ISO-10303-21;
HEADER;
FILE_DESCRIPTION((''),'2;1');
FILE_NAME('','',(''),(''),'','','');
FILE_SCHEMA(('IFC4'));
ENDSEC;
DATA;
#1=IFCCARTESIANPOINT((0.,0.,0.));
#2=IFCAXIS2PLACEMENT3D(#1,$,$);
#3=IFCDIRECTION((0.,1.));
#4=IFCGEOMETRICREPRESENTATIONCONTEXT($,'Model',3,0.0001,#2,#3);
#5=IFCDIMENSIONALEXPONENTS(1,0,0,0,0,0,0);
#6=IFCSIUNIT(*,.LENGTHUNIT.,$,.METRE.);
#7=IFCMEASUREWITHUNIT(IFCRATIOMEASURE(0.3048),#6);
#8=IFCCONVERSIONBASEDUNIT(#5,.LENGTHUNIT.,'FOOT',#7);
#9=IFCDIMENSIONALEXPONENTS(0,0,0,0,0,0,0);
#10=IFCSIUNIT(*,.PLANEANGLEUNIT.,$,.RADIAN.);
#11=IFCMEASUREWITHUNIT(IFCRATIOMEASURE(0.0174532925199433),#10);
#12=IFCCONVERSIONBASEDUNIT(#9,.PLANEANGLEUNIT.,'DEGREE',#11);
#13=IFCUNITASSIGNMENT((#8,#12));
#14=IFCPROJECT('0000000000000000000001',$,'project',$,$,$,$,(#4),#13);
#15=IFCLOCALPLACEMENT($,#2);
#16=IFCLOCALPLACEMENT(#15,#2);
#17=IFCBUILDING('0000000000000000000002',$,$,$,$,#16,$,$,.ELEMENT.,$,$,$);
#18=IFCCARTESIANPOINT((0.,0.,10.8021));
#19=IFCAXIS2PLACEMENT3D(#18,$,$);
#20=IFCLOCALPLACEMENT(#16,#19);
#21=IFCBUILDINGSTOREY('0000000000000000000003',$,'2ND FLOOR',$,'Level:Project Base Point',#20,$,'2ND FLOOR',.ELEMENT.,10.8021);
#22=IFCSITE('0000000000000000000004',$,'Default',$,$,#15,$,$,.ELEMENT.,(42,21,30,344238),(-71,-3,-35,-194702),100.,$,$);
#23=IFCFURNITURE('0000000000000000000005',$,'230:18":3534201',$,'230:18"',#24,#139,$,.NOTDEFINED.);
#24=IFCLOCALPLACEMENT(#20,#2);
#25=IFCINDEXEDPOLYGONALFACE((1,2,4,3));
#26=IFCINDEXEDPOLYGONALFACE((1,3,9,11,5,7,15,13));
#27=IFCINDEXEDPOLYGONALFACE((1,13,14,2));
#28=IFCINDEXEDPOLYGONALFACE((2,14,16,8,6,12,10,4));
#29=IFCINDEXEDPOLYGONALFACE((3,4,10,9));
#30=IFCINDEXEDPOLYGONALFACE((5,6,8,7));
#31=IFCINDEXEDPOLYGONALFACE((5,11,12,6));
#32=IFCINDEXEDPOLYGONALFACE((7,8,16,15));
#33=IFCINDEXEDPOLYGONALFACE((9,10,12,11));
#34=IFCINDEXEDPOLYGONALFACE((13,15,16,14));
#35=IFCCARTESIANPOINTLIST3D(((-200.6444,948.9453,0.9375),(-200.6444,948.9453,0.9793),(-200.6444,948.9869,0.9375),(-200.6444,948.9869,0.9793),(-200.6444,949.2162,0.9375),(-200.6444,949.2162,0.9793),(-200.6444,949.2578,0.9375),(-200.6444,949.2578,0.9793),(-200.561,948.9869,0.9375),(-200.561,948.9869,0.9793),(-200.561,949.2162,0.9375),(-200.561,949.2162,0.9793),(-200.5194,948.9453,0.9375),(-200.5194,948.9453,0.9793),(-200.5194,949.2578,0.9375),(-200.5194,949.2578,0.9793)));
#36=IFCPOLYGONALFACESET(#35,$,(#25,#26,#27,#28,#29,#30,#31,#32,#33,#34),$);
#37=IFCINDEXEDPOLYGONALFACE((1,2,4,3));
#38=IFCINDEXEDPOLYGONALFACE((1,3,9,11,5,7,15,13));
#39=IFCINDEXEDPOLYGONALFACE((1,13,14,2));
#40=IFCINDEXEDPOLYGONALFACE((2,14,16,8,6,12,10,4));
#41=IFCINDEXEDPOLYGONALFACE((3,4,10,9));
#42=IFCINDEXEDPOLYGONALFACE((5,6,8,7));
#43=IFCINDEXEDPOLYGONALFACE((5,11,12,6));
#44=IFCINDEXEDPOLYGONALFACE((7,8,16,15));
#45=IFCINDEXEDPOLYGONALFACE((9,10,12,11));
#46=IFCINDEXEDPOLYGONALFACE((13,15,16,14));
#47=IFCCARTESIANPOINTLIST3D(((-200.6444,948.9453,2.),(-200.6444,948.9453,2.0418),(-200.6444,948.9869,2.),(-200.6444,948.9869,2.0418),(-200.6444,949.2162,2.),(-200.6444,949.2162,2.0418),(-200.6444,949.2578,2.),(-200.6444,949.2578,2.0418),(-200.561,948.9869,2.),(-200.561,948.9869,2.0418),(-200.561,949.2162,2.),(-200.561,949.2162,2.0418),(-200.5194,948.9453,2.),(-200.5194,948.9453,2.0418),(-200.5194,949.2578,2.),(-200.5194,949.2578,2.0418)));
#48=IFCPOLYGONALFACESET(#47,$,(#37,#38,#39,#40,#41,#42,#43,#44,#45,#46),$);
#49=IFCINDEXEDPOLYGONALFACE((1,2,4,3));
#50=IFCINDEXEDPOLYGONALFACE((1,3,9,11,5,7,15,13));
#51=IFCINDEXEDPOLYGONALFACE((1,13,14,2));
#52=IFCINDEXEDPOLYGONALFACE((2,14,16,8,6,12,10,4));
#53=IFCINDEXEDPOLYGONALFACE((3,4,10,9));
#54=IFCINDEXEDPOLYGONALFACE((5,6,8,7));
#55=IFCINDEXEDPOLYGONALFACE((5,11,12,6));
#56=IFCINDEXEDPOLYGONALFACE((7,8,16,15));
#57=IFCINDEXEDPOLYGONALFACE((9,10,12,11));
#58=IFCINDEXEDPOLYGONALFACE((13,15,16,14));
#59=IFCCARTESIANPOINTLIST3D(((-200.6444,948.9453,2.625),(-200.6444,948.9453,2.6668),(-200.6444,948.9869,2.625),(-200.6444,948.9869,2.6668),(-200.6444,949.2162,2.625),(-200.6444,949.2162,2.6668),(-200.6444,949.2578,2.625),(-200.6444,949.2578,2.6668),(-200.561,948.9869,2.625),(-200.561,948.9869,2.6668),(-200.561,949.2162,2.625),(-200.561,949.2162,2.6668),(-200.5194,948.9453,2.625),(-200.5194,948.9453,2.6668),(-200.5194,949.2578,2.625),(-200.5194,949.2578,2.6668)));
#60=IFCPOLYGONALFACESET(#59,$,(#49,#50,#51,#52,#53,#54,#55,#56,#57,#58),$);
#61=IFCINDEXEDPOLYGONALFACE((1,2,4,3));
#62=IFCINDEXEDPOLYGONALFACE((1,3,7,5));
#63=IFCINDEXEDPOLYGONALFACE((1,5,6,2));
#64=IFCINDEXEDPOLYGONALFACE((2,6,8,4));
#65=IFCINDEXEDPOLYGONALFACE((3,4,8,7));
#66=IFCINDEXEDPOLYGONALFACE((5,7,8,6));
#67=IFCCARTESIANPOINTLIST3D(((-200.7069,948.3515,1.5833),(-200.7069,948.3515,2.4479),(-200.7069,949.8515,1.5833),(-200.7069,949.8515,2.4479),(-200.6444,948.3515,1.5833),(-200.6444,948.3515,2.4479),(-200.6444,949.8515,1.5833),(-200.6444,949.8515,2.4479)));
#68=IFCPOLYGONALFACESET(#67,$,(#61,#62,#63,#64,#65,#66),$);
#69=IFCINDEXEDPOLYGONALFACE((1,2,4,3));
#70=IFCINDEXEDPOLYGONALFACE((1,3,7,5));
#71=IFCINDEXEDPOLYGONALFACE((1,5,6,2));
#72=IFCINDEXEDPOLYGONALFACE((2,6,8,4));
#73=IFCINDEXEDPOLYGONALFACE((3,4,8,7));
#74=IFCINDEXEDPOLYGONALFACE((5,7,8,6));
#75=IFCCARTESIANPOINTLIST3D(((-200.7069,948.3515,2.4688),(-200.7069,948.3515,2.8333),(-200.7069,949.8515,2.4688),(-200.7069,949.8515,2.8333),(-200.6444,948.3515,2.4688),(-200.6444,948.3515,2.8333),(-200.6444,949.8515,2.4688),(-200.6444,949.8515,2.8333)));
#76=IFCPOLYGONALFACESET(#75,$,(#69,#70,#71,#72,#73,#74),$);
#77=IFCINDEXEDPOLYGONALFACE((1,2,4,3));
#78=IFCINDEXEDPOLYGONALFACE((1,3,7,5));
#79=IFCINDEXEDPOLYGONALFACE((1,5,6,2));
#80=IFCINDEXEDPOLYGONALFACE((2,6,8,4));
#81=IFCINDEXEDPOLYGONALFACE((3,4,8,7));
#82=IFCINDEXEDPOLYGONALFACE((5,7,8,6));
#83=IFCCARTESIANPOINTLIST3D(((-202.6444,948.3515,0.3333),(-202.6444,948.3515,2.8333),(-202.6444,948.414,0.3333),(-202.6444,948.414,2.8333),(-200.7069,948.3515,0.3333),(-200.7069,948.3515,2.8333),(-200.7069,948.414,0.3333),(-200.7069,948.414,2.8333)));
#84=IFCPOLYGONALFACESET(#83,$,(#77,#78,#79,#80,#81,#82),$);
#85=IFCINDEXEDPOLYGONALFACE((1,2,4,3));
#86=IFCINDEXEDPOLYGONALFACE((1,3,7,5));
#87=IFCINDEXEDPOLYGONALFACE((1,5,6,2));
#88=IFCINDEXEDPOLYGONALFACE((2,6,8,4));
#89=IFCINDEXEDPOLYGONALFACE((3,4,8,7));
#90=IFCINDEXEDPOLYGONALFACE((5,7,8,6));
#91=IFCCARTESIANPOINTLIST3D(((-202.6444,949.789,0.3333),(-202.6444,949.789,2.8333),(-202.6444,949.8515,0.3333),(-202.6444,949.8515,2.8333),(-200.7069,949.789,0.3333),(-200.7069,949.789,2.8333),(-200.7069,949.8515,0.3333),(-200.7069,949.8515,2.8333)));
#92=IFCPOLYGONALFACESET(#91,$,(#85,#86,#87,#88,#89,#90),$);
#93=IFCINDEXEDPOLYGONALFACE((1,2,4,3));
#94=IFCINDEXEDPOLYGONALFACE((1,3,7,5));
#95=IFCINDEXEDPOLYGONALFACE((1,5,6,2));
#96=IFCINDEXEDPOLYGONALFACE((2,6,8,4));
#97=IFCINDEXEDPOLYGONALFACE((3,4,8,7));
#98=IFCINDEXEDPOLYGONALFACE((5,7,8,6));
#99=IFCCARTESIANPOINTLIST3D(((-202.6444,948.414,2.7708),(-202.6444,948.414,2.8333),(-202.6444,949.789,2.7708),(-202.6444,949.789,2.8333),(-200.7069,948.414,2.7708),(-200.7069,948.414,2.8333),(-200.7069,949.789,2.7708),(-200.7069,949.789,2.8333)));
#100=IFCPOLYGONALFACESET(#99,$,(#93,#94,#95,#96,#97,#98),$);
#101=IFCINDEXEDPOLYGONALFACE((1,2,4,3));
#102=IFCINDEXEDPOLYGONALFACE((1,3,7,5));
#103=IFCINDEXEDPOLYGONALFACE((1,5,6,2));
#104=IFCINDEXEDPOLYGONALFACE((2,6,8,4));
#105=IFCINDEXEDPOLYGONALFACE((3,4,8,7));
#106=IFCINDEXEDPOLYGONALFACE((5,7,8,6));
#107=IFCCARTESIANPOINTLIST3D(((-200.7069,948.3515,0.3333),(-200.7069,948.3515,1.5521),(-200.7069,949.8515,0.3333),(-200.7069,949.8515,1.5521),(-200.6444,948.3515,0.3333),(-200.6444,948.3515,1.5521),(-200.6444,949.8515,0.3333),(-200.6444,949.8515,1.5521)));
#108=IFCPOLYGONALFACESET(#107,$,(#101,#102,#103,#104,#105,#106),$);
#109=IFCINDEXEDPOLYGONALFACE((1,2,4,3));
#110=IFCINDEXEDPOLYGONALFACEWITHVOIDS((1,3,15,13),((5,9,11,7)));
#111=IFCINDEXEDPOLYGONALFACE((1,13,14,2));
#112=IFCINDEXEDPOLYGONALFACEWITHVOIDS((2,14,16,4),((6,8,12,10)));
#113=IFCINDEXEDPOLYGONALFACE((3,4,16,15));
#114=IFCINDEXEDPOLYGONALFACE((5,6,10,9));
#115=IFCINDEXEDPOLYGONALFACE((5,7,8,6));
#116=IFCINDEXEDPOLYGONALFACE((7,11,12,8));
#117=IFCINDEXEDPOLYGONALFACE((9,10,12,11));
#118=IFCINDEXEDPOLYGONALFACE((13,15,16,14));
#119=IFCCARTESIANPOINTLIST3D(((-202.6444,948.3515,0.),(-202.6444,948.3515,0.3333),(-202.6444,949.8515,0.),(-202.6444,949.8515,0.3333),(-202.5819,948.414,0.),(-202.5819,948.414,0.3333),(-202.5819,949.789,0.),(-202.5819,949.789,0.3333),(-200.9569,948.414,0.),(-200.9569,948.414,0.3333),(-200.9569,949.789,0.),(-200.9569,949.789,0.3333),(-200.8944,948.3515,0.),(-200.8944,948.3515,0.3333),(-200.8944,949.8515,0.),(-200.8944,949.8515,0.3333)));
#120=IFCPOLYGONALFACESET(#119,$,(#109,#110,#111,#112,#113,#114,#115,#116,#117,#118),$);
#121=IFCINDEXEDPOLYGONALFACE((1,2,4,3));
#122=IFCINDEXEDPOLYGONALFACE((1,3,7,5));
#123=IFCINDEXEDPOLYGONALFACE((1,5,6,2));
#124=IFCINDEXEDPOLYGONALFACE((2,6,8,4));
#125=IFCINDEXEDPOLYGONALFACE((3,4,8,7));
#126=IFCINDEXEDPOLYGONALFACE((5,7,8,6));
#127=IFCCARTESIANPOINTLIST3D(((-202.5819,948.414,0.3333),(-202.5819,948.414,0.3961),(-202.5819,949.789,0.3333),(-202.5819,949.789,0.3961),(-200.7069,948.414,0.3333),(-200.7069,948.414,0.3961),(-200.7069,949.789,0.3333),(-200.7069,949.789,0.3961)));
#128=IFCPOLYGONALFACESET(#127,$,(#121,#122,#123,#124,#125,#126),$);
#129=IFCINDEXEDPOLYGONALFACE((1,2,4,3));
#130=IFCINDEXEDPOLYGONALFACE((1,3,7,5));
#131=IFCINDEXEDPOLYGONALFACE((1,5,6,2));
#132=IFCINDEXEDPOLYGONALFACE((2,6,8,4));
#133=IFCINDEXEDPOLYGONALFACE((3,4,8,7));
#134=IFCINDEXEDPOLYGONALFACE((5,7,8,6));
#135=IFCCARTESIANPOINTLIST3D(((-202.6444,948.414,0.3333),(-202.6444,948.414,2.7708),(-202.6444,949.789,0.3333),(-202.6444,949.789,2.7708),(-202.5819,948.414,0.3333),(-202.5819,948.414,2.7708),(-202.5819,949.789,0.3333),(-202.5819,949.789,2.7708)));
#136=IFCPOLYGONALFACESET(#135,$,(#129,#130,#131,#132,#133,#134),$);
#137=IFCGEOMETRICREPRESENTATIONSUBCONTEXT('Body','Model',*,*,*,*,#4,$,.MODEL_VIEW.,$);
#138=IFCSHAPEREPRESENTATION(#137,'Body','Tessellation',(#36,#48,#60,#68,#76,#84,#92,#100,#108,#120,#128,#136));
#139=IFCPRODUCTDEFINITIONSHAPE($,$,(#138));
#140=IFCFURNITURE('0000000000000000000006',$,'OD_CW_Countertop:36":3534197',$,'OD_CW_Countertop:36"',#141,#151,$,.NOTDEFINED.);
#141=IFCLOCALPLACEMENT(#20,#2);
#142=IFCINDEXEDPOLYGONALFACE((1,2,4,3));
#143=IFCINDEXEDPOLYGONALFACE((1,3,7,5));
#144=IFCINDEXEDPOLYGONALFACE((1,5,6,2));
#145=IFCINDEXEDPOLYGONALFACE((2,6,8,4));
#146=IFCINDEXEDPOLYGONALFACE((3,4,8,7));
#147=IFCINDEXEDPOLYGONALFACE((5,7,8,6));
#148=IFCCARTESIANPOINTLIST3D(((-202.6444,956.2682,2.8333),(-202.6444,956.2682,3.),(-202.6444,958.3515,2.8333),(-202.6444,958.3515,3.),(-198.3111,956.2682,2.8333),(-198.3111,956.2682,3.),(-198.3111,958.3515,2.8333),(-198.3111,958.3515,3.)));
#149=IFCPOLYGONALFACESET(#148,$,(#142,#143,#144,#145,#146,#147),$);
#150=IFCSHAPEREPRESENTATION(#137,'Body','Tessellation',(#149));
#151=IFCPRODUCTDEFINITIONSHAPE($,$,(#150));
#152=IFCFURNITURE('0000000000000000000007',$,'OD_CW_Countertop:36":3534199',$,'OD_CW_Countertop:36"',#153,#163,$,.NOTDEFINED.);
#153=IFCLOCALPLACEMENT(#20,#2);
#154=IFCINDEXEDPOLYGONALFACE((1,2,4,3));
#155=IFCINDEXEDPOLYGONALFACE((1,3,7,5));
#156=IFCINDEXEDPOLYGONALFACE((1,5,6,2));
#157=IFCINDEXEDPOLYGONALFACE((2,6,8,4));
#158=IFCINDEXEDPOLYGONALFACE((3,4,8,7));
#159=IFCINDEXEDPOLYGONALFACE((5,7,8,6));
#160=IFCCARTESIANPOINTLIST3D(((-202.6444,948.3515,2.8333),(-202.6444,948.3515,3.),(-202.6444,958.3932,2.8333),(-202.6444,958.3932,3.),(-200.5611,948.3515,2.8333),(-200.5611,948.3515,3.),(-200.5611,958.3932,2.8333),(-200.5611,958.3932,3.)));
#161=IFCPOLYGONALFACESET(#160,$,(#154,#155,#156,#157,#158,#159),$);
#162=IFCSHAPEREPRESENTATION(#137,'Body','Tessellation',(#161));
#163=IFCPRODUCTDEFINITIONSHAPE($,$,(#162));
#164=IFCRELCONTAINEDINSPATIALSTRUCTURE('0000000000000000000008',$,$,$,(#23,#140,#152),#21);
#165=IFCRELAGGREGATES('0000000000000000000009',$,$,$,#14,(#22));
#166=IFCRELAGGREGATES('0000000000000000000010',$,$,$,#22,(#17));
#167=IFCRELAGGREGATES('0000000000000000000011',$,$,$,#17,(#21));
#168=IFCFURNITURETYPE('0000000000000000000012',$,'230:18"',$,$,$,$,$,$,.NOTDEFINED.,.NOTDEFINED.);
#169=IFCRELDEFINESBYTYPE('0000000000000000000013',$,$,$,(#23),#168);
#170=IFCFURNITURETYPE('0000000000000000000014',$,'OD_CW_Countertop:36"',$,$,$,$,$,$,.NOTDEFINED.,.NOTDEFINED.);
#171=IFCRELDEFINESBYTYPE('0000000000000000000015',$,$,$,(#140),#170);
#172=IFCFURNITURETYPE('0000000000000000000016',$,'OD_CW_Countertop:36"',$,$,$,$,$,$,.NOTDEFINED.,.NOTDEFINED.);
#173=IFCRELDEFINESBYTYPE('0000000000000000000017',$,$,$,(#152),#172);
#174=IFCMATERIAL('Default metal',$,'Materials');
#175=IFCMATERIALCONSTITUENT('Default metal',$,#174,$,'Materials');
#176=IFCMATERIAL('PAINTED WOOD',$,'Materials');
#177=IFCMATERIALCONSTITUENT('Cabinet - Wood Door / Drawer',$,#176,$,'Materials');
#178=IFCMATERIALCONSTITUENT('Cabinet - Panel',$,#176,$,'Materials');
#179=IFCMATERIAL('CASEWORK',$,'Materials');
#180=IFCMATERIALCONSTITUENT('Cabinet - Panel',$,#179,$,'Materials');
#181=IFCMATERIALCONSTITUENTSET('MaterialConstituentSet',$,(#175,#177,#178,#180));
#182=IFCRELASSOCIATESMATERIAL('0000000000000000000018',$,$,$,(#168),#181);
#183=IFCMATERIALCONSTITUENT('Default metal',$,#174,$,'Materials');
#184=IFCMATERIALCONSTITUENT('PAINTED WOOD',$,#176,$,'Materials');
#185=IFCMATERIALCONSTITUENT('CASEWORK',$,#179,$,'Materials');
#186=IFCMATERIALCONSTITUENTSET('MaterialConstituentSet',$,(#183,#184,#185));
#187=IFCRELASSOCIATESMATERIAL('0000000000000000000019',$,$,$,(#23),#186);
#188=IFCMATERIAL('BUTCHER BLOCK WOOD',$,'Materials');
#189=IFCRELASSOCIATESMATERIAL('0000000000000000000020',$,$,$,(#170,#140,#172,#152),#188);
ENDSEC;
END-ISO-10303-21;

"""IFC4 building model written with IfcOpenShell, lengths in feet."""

from ifc_helpers import new_model, entity, si_unit, converted_unit, direction, frame, frame_2d, origin, origin_2d_with_axis, place, context, subcontext, project, spatial, polyline, rectangle, outline, extrude, source, transform, mapped, material, constituent, constituent_set, type_object, type_shapes, element, save


model = new_model("IFC4")

# Units and contexts
model_context = context("Model", 3, precision=0.0001, world=origin(), true_north=direction((0.0, 1.0)))
body_context = subcontext(model_context, "Body", "Model", "MODEL_VIEW")
ifc_project = project(units=[converted_unit("LENGTHUNIT", "FOOT", entity("IfcRatioMeasure", 0.3048), si_unit("LENGTHUNIT", "METRE"), dimensions=[1, 0, 0, 0, 0, 0, 0]), converted_unit("PLANEANGLEUNIT", "DEGREE", entity("IfcRatioMeasure", 0.0174532925199433), si_unit("PLANEANGLEUNIT", "RADIAN"), dimensions=[0, 0, 0, 0, 0, 0, 0])], contexts=[model_context])

# Site, building, storey
site_placement = place(None, origin())
site = spatial("IfcSite", under=ifc_project, at=site_placement, Name="Default", CompositionType="ELEMENT", RefLatitude=(42, 21, 30, 344238), RefLongitude=(-71, -3, -35, -194702), RefElevation=100.0)
building_placement = place(site_placement, origin())
building = spatial("IfcBuilding", under=site, at=building_placement, CompositionType="ELEMENT")
storey_placement = place(building_placement, frame((0.0, 0.0, 10.8021)))
storey = spatial("IfcBuildingStorey", under=building, at=storey_placement, Name="2ND FLOOR", ObjectType="Level:Project Base Point", LongName="2ND FLOOR", CompositionType="ELEMENT", Elevation=10.8021)

# Furniture
ifc_material_1 = material(Name="CASEWORK", Category="Materials")
ifc_material_2 = material(Name="Default metal", Category="Materials")
ifc_material_3 = material(Name="PAINTED WOOD", Category="Materials")
ifc_constituent_1 = constituent(ifc_material_2, Name="Default metal", Category="Materials")
ifc_constituent_2 = constituent(ifc_material_3, Name="PAINTED WOOD", Category="Materials")
ifc_constituent_3 = constituent(ifc_material_1, Name="CASEWORK", Category="Materials")
ifc_constituent_set_1 = constituent_set(constituents=[ifc_constituent_1, ifc_constituent_2, ifc_constituent_3], Name="MaterialConstituentSet")
ifc_constituent_4 = constituent(ifc_material_2, Name="Default metal", Category="Materials")
ifc_constituent_5 = constituent(ifc_material_3, Name="Cabinet - Wood Door / Drawer", Category="Materials")
ifc_constituent_6 = constituent(ifc_material_3, Name="Cabinet - Panel", Category="Materials")
ifc_constituent_7 = constituent(ifc_material_1, Name="Cabinet - Panel", Category="Materials")
ifc_constituent_set_2 = constituent_set(constituents=[ifc_constituent_4, ifc_constituent_5, ifc_constituent_6, ifc_constituent_7], Name="MaterialConstituentSet")
furniture_type_1 = type_object("IfcFurnitureType", Name="230:18\"", AssemblyPlace="NOTDEFINED", PredefinedType="NOTDEFINED", material=ifc_constituent_set_2)
shared_shape_1 = source(origin(), body_context, "Body", "SweptSolid", [
    extrude(outline(polyline([(-0.0521, -0.1562), (0.0729, -0.1562), (0.0729, 0.1562), (-0.0521, 0.1562), (-0.0521, 0.1146), (0.0313, 0.1146), (0.0313, -0.1146), (-0.0521, -0.1146), (-0.0521, -0.1562)])), frame((0.0615, -2.0521, 0.9375), z_axis=(0.0, 0.0, 1.0), x_axis=(0.0, -1.0, 0.0)), (0.0, 0.0, 1.0), 0.0418),
    extrude(outline(polyline([(-0.0521, -0.1562), (0.0729, -0.1562), (0.0729, 0.1562), (-0.0521, 0.1562), (-0.0521, 0.1146), (0.0313, 0.1146), (0.0313, -0.1146), (-0.0521, -0.1146), (-0.0521, -0.1562)])), frame((0.0615, -2.0521, 2.0), z_axis=(0.0, 0.0, 1.0), x_axis=(0.0, -1.0, 0.0)), (0.0, 0.0, 1.0), 0.0418),
    extrude(outline(polyline([(-0.0521, -0.1562), (0.0729, -0.1562), (0.0729, 0.1562), (-0.0521, 0.1562), (-0.0521, 0.1146), (0.0313, 0.1146), (0.0313, -0.1146), (-0.0521, -0.1146), (-0.0521, -0.1562)])), frame((0.0615, -2.0521, 2.625), z_axis=(0.0, 0.0, 1.0), x_axis=(0.0, -1.0, 0.0)), (0.0, 0.0, 1.0), 0.0418),
    extrude(rectangle(XDim=0.0625, YDim=1.5, at=frame_2d((0.0, 0.0), x_axis=(1.0, 0.0))), frame((0.0615, -1.9688, 1.5833), z_axis=(0.0, 0.0, 1.0), x_axis=(0.0, 1.0, 0.0)), (0.0, 0.0, 1.0), 0.8646),
    extrude(rectangle(XDim=0.0625, YDim=1.5, at=frame_2d((0.0, 0.0), x_axis=(1.0, 0.0))), frame((0.0615, -1.9688, 2.4688), z_axis=(0.0, 0.0, 1.0), x_axis=(0.0, 1.0, 0.0)), (0.0, 0.0, 1.0), 0.3646),
    extrude(rectangle(XDim=0.0625, YDim=1.9375, at=frame_2d((0.0, 0.0), x_axis=(1.0, 0.0))), frame((-0.6573, -0.9687, 0.3333)), (0.0, 0.0, 1.0), 2.5),
    extrude(rectangle(XDim=0.0625, YDim=1.9375, at=frame_2d((0.0, 0.0), x_axis=(1.0, 0.0))), frame((0.7802, -0.9687, 0.3333)), (0.0, 0.0, 1.0), 2.5),
    extrude(rectangle(XDim=1.375, YDim=1.9375, at=origin_2d_with_axis()), frame((0.0615, -0.9687, 2.7708), z_axis=(0.0, 0.0, 1.0), x_axis=(-1.0, 0.0, 0.0)), (0.0, 0.0, 1.0), 0.0625),
    extrude(rectangle(XDim=0.0625, YDim=1.5, at=frame_2d((0.0, 0.0), x_axis=(1.0, 0.0))), frame((0.0615, -1.9688, 0.3333), z_axis=(0.0, 0.0, 1.0), x_axis=(0.0, 1.0, 0.0)), (0.0, 0.0, 1.0), 1.2187),
    extrude(outline(polyline([(-0.75, -0.875), (0.75, -0.875), (0.75, 0.875), (-0.75, 0.875), (-0.75, -0.875)]), holes=[polyline([(-0.6875, -0.8125), (-0.6875, 0.8125), (0.6875, 0.8125), (0.6875, -0.8125), (-0.6875, -0.8125)])]), frame((0.0615, -0.875, 0.0)), (0.0, 0.0, 1.0), 0.3333),
    extrude(rectangle(XDim=1.375, YDim=1.875, at=frame_2d((0.0, 0.0), x_axis=(1.0, 0.0))), frame((0.0615, -1.0, 0.3333), z_axis=(0.0, 0.0, 1.0), x_axis=(-1.0, 0.0, 0.0)), (0.0, 0.0, 1.0), 0.0627),
    extrude(rectangle(XDim=0.0625, YDim=1.375, at=origin_2d_with_axis()), frame((0.0615, -0.0312, 0.3333), z_axis=(0.0, 0.0, 1.0), x_axis=(0.0, 1.0, 0.0)), (0.0, 0.0, 1.0), 2.4375),
])
type_shapes(furniture_type_1, [shared_shape_1])
furniture_1_placement = place(storey_placement, frame((-202.6444, 949.04, 0.0), z_axis=(0.0, 0.0, 1.0), x_axis=(0.0, 1.0, 0.0)))
element("IfcFurniture", 1, at=furniture_1_placement, inside=storey, type_object=furniture_type_1, material=ifc_constituent_set_1, Name="230:18\":3534201", ObjectType="230:18\"", PredefinedType="NOTDEFINED", context=body_context, shape_type="MappedRepresentation", body=[
    mapped(shared_shape_1, transform((0.0, 0.0, 0.0), scale=1.0)),
])
ifc_material_4 = material(Name="BUTCHER BLOCK WOOD", Category="Materials")
furniture_type_2 = type_object("IfcFurnitureType", Name="OD_CW_Countertop:36\"", AssemblyPlace="NOTDEFINED", PredefinedType="NOTDEFINED", material=ifc_material_4)
shared_shape_2 = source(origin(), body_context, "Body", "SweptSolid", [
    extrude(rectangle(XDim=4.3333, YDim=2.0833, at=origin_2d_with_axis()), frame((2.1667, 1.0417, 0.0)), (0.0, 0.0, 1.0), 0.1667),
])
type_shapes(furniture_type_2, [shared_shape_2])
furniture_2_placement = place(storey_placement, frame((-198.3111, 958.3515, 2.8333), z_axis=(0.0, 0.0, 1.0), x_axis=(-1.0, 0.0, 0.0)))
element("IfcFurniture", 2, at=furniture_2_placement, inside=storey, type_object=furniture_type_2, material=ifc_material_4, Name="OD_CW_Countertop:36\":3534197", ObjectType="OD_CW_Countertop:36\"", PredefinedType="NOTDEFINED", context=body_context, shape_type="MappedRepresentation", body=[
    mapped(shared_shape_2, transform((0.0, 0.0, 0.0), scale=1.0)),
])
furniture_type_3 = type_object("IfcFurnitureType", Name="OD_CW_Countertop:36\"", AssemblyPlace="NOTDEFINED", PredefinedType="NOTDEFINED", material=ifc_material_4)
shared_shape_3 = source(origin(), body_context, "Body", "SweptSolid", [
    extrude(rectangle(XDim=10.0417, YDim=2.0833, at=origin_2d_with_axis()), frame((5.0208, 1.0417, 0.0)), (0.0, 0.0, 1.0), 0.1667),
])
type_shapes(furniture_type_3, [shared_shape_3])
furniture_3_placement = place(storey_placement, frame((-202.6444, 958.3932, 2.8333), z_axis=(0.0, 0.0, 1.0), x_axis=(0.0, -1.0, 0.0)))
element("IfcFurniture", 3, at=furniture_3_placement, inside=storey, type_object=furniture_type_3, material=ifc_material_4, Name="OD_CW_Countertop:36\":3534199", ObjectType="OD_CW_Countertop:36\"", PredefinedType="NOTDEFINED", context=body_context, shape_type="MappedRepresentation", body=[
    mapped(shared_shape_3, transform((0.0, 0.0, 0.0), scale=1.0)),
])

save(model, "model.ifc")
